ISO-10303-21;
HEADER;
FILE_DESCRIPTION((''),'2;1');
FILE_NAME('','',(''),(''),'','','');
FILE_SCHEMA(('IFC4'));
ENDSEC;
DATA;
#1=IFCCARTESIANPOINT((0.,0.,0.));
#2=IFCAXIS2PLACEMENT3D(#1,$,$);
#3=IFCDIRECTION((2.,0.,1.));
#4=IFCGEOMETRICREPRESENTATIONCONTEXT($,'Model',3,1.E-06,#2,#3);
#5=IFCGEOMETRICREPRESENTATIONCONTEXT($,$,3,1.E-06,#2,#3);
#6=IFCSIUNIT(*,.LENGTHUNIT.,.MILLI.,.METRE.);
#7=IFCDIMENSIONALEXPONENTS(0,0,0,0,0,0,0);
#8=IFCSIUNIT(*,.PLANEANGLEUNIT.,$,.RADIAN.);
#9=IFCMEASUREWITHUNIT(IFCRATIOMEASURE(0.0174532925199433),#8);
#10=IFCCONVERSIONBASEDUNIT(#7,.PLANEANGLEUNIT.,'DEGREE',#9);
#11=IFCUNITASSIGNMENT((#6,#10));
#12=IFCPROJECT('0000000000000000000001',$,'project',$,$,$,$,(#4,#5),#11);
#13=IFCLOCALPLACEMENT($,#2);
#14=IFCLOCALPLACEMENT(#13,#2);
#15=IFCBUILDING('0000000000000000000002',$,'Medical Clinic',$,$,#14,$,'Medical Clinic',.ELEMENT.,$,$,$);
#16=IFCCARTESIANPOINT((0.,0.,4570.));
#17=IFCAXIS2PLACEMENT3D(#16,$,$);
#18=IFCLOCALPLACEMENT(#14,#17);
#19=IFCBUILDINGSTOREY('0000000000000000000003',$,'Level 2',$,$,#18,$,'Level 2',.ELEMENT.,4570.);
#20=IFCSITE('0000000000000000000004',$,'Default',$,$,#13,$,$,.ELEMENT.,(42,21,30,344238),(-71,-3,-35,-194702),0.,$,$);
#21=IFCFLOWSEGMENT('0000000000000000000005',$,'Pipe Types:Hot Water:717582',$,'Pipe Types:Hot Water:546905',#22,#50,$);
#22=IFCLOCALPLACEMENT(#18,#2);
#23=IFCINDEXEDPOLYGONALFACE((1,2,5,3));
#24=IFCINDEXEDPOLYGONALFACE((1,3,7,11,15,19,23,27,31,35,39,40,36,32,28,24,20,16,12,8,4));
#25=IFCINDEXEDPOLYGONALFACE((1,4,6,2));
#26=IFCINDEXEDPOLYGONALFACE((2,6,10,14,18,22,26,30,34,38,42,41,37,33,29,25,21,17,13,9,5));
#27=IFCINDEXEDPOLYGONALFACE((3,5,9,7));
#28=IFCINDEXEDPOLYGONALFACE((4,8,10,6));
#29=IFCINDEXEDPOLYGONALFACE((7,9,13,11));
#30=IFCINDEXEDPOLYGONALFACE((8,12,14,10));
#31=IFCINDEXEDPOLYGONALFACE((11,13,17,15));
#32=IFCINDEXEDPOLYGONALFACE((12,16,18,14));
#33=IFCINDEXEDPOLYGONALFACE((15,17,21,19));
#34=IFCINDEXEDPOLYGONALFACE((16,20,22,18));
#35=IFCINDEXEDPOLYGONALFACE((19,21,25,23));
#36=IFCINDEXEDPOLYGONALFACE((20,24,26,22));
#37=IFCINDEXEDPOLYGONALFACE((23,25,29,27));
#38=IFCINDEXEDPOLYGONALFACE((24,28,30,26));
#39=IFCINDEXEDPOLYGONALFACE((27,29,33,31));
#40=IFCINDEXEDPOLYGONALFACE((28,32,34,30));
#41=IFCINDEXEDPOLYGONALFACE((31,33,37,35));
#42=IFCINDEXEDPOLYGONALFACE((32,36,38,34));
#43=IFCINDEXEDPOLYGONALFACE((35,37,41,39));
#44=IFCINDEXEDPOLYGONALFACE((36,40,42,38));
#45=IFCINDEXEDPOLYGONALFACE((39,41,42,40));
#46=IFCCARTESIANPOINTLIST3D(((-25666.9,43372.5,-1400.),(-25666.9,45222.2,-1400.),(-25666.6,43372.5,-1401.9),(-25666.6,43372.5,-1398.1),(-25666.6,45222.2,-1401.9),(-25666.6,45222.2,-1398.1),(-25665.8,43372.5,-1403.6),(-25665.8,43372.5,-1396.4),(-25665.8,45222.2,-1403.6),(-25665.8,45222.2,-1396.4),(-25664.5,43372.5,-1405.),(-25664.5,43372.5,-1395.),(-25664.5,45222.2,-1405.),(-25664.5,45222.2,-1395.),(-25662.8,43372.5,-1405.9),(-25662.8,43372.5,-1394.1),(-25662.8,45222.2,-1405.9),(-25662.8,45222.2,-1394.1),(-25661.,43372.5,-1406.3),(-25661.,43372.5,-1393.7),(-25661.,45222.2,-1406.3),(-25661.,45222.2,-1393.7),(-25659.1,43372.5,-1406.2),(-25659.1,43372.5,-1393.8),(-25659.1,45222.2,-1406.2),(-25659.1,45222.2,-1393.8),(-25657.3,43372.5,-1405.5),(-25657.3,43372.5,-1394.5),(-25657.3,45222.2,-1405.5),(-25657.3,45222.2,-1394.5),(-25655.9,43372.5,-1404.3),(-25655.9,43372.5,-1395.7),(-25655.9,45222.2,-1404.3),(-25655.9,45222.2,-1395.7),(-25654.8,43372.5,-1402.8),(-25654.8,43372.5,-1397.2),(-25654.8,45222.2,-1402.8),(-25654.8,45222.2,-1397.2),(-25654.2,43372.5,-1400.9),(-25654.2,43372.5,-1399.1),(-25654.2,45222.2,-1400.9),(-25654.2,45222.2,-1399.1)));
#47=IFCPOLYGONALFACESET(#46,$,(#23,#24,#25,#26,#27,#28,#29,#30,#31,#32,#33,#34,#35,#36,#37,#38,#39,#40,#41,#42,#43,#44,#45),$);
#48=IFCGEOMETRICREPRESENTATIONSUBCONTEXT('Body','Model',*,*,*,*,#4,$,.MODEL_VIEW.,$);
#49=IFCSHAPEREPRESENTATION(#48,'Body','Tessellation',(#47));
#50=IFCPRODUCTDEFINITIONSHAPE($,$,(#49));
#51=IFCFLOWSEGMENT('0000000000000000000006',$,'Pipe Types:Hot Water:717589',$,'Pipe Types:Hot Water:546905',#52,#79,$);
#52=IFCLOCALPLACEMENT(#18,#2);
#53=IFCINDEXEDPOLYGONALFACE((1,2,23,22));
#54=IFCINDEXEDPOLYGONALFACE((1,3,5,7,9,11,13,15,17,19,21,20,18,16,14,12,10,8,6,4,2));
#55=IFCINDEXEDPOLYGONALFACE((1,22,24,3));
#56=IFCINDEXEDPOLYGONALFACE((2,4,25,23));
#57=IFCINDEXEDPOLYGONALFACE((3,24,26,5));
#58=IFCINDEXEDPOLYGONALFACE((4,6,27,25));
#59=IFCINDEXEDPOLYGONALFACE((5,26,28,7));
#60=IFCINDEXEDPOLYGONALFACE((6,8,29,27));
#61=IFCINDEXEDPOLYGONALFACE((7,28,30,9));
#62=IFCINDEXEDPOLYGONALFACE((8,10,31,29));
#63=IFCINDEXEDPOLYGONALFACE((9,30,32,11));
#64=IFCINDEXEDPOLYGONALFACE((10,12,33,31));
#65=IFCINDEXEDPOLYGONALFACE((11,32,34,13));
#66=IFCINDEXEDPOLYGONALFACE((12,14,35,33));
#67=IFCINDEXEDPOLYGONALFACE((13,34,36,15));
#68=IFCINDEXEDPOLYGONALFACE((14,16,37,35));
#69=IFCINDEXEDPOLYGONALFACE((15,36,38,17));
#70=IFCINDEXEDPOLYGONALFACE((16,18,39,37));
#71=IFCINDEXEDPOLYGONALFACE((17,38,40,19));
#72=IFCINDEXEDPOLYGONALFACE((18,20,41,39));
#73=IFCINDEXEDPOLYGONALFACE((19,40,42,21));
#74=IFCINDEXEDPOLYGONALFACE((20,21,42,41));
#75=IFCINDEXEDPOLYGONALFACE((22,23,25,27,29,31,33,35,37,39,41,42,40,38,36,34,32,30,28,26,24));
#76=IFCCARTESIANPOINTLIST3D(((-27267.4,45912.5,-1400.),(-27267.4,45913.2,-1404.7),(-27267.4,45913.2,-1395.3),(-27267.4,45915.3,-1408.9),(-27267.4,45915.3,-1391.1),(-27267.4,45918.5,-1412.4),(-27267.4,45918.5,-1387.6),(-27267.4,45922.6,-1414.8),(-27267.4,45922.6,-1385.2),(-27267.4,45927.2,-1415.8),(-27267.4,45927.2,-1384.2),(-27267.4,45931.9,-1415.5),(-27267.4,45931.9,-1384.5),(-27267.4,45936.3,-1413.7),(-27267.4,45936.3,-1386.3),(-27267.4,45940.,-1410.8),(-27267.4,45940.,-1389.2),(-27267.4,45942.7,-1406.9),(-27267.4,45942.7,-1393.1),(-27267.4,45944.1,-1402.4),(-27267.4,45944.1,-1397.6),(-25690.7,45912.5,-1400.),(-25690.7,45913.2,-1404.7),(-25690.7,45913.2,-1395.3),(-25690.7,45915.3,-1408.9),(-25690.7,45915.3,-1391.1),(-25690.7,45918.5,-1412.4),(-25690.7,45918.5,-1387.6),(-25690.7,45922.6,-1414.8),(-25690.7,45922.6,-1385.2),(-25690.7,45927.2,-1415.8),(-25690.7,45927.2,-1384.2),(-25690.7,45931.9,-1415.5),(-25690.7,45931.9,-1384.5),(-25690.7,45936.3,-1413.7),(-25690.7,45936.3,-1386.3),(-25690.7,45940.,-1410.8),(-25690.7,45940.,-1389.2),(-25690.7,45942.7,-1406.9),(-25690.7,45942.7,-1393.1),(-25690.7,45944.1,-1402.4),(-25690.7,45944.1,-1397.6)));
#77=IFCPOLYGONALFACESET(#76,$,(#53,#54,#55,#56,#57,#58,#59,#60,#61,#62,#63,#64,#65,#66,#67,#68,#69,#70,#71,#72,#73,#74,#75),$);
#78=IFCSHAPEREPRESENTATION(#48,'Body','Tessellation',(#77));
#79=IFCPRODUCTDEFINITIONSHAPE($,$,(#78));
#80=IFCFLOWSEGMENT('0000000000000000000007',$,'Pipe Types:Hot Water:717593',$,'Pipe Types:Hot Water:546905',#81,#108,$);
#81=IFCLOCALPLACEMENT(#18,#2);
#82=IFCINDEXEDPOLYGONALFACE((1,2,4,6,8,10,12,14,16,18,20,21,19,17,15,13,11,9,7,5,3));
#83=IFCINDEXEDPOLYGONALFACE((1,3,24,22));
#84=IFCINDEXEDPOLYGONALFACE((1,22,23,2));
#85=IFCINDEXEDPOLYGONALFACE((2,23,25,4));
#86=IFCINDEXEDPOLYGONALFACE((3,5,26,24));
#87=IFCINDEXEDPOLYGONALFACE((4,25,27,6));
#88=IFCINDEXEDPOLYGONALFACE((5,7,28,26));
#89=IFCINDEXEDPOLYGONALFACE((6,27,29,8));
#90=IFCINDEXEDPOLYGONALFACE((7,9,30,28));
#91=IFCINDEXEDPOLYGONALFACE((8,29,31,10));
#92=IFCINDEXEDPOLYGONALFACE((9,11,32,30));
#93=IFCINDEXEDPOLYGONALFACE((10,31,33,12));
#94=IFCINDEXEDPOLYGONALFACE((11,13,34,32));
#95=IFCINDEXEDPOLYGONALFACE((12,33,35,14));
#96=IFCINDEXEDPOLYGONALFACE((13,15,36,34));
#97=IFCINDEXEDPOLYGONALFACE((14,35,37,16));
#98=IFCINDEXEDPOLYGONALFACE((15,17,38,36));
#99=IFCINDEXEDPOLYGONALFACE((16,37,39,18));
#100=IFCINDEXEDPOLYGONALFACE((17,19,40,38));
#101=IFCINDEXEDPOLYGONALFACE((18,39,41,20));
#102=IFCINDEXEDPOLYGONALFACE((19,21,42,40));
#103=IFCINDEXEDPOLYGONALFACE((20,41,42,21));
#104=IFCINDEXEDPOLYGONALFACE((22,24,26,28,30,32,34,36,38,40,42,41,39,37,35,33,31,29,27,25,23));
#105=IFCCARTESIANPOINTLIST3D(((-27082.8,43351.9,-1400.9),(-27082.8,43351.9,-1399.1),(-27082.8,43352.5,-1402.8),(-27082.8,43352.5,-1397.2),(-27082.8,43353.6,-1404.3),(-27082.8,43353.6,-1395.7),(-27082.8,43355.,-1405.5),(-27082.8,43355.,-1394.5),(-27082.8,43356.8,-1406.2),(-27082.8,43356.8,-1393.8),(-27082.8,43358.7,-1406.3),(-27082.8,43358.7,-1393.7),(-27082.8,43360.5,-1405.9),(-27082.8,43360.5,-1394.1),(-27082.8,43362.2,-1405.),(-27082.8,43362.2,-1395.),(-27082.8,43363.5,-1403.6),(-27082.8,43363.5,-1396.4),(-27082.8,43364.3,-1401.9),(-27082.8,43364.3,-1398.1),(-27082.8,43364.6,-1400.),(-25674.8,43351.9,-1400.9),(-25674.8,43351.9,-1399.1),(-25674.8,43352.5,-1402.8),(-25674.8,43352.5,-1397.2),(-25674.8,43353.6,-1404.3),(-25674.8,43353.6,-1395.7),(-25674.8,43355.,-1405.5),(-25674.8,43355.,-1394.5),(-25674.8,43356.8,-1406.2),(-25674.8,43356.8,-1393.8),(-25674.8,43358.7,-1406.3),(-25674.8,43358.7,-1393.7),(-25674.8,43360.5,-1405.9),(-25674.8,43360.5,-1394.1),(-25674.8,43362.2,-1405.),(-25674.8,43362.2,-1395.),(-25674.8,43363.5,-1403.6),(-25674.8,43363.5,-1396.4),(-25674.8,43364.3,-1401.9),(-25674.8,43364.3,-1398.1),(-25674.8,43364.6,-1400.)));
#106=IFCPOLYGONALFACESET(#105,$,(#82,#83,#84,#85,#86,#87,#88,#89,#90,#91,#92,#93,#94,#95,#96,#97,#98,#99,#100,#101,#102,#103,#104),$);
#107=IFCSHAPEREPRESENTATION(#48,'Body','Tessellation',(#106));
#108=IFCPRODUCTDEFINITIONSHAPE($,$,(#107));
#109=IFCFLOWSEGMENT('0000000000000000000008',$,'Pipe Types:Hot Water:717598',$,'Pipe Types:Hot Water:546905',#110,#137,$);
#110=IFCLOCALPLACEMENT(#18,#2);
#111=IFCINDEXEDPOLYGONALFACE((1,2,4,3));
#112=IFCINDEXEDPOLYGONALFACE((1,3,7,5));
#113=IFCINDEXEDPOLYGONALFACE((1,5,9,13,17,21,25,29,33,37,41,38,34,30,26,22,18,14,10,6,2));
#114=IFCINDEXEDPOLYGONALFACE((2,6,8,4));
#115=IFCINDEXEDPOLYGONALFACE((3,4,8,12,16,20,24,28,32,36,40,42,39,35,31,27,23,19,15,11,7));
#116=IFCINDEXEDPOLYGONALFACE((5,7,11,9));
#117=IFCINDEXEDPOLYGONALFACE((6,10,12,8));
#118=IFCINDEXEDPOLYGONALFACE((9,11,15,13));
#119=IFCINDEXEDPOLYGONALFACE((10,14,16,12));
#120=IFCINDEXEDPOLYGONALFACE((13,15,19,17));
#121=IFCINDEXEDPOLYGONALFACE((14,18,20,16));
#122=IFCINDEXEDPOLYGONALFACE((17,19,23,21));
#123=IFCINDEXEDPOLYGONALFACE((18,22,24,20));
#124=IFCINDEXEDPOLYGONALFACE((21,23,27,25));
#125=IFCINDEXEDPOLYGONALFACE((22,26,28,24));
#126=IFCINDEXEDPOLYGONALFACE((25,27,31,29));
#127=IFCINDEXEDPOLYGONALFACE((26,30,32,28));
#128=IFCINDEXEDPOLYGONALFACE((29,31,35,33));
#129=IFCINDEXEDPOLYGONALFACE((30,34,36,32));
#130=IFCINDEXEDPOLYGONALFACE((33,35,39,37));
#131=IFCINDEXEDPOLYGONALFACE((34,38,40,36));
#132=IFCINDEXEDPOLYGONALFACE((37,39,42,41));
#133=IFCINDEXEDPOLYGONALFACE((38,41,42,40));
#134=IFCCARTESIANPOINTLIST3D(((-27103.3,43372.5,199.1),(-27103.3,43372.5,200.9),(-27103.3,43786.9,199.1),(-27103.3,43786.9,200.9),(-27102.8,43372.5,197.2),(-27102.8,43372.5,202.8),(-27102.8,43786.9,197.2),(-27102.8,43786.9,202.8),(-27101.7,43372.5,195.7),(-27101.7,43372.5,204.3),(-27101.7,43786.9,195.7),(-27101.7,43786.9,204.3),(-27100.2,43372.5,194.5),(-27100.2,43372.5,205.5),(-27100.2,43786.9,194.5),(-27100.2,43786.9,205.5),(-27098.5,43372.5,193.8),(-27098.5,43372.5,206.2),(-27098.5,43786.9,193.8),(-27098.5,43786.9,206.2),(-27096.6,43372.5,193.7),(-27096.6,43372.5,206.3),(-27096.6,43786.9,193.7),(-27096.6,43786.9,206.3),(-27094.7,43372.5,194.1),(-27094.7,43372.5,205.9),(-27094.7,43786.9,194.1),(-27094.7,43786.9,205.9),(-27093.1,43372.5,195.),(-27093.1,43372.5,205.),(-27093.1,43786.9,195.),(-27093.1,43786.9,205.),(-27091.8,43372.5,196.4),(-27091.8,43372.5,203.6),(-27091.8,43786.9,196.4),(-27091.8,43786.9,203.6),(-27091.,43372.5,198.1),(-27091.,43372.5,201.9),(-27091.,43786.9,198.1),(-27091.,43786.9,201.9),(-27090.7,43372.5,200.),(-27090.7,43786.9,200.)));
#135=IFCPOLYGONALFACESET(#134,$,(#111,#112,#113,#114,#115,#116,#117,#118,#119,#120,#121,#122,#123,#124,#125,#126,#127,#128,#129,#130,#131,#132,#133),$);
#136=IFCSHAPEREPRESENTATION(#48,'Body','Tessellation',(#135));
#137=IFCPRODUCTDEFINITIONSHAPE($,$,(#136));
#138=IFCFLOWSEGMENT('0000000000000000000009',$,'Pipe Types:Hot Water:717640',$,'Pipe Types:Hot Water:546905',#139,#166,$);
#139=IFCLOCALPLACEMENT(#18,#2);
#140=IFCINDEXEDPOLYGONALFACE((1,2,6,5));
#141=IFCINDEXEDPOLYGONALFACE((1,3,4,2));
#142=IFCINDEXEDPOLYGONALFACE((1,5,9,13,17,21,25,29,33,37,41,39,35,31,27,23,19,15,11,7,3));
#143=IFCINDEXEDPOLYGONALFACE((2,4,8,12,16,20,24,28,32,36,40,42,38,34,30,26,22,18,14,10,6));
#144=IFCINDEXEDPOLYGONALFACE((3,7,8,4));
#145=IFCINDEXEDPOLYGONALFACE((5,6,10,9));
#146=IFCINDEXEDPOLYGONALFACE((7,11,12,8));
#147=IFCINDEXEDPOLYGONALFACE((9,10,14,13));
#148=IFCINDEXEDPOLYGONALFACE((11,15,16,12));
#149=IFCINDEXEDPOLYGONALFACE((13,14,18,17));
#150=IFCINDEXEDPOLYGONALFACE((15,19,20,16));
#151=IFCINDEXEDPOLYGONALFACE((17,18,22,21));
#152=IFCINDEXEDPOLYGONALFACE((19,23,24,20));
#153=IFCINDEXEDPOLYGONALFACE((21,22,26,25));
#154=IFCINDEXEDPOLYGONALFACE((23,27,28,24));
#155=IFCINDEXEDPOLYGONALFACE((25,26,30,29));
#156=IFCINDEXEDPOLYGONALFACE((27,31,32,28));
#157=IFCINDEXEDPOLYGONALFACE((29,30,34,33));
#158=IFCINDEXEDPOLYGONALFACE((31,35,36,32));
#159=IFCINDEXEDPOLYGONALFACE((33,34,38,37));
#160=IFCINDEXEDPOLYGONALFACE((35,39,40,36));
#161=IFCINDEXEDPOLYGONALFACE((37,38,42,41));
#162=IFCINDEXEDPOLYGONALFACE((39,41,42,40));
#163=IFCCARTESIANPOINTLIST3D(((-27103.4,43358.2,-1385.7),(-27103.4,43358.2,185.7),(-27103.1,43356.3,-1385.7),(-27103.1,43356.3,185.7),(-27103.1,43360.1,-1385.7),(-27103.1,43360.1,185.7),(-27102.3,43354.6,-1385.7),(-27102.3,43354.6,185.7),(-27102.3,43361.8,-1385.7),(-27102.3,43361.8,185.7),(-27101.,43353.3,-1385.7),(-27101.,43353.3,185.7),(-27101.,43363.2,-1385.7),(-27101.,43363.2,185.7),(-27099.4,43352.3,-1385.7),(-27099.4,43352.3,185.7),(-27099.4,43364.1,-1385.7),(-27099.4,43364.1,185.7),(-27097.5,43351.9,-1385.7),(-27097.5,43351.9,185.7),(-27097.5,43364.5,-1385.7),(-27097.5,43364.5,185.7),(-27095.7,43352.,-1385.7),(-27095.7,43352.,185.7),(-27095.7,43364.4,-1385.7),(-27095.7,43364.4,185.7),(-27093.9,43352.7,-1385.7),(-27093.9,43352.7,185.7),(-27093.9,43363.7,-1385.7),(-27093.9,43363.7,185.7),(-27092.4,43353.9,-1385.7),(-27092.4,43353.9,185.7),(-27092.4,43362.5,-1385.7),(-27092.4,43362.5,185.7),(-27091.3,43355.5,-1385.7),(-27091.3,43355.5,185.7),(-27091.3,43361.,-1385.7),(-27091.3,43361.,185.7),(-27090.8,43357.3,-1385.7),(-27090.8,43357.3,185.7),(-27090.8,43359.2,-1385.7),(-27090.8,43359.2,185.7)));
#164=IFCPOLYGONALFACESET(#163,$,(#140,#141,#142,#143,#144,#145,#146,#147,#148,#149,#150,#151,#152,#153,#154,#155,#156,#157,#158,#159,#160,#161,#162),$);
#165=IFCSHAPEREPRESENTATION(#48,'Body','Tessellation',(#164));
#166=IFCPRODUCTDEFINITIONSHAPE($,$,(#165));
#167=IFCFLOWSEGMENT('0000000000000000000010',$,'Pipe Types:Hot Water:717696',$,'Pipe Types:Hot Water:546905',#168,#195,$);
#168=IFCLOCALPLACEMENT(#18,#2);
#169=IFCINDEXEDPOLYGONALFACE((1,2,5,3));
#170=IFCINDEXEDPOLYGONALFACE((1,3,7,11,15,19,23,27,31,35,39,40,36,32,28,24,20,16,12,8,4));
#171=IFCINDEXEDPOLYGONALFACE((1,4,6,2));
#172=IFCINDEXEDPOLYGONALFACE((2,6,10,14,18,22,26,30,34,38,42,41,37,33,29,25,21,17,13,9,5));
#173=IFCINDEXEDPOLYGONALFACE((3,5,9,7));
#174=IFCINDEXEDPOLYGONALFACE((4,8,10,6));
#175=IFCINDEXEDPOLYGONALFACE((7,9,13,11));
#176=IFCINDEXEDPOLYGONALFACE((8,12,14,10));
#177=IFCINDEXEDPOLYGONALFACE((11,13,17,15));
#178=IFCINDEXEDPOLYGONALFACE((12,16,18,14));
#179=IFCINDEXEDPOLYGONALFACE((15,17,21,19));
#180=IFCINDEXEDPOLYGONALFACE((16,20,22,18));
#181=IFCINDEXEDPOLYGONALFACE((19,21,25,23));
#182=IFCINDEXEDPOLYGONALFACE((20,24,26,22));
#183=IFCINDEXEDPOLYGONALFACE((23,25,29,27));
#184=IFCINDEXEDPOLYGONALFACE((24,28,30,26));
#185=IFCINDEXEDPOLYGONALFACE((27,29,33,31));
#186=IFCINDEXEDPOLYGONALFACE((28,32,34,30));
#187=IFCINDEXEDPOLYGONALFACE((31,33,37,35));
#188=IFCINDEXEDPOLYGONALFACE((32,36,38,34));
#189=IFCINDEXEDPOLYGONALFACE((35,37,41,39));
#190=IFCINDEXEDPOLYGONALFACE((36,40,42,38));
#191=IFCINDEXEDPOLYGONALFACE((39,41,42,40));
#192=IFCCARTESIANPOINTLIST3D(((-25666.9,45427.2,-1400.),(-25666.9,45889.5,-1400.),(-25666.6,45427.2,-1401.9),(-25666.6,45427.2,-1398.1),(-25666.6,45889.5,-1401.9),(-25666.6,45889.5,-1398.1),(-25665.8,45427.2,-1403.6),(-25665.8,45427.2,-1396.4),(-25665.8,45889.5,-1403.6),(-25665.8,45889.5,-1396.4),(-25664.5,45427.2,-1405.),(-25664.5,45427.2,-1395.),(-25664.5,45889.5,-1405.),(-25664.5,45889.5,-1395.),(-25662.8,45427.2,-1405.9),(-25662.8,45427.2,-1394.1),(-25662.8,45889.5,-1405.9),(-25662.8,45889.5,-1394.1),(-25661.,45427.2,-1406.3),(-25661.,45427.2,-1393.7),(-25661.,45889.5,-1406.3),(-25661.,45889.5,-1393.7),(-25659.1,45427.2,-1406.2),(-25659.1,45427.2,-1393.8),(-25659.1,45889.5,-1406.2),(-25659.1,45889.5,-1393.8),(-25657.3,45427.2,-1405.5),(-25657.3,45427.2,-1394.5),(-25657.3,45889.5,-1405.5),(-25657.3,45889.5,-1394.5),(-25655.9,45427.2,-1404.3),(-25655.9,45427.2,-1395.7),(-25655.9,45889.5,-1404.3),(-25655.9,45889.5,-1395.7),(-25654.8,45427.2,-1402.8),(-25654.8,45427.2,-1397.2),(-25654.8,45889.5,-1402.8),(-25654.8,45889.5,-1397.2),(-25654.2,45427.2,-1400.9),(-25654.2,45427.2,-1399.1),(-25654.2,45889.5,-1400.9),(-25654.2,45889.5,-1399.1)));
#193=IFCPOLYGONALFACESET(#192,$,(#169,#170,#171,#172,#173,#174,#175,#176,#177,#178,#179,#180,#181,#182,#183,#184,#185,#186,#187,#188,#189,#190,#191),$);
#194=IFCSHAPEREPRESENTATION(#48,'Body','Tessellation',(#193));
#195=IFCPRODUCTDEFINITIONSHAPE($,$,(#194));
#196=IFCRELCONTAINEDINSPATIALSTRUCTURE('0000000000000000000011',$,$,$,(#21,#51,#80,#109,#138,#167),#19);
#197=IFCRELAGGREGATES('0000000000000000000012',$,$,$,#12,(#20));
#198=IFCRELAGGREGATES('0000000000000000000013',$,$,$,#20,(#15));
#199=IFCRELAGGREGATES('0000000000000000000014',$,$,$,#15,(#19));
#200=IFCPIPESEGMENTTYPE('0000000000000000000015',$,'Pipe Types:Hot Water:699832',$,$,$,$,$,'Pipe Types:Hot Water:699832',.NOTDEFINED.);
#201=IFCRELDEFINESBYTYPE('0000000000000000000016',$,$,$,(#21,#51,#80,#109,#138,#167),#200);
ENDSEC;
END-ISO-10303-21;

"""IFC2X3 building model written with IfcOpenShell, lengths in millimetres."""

from ifc_helpers import new_model, entity, si_unit, converted_unit, direction, frame, frame_2d, origin, origin_2d_with_axis, place, context, subcontext, project, spatial, circle, extrude, type_object, element, save


model = new_model("IFC2X3")

# Units and contexts
model_context = context("Model", 3, precision=1e-06, world=origin(), true_north=direction((2.0, 0.0, 1.0)))
context_of_model = context(None, 3, precision=1e-06, world=origin(), true_north=direction((2.0, 0.0, 1.0)))
body_context = subcontext(model_context, "Body", "Model", "MODEL_VIEW")
ifc_project = project(units=[si_unit("LENGTHUNIT", "METRE", prefix="MILLI"), converted_unit("PLANEANGLEUNIT", "DEGREE", entity("IfcRatioMeasure", 0.0174532925199433), si_unit("PLANEANGLEUNIT", "RADIAN"), dimensions=[0, 0, 0, 0, 0, 0, 0])], contexts=[model_context, context_of_model])

# Site, building, storey
site_placement = place(None, origin())
site = spatial("IfcSite", under=ifc_project, at=site_placement, Name="Default", CompositionType="ELEMENT", RefLatitude=(42, 21, 30, 344238), RefLongitude=(-71, -3, -35, -194702), RefElevation=0.0)
building_placement = place(site_placement, origin())
building = spatial("IfcBuilding", under=site, at=building_placement, Name="Medical Clinic", LongName="Medical Clinic", CompositionType="ELEMENT")
storey_placement = place(building_placement, frame((0.0, 0.0, 4570.0)))
storey = spatial("IfcBuildingStorey", under=building, at=storey_placement, Name="Level 2", LongName="Level 2", CompositionType="ELEMENT", Elevation=4570.0)

# Flow segments
pipe_segment_type = type_object("IfcPipeSegmentType", Name="Pipe Types:Hot Water:699832", ElementType="Pipe Types:Hot Water:699832", PredefinedType="NOTDEFINED")
flow_segment_1_placement = place(storey_placement, origin())
element("IfcFlowSegment", 1, at=flow_segment_1_placement, inside=storey, type_object=pipe_segment_type, Name="Pipe Types:Hot Water:717582", ObjectType="Pipe Types:Hot Water:546905", context=body_context, shape_type="SweptSolid", body=[
    extrude(circle(Radius=6.3, at=frame_2d((0.0, 0.0), x_axis=(1.0, 0.0))), frame((-25660.5, 43372.5, -1400.0), z_axis=(0.0, 1.0, 0.0), x_axis=(-1.0, 0.0, 0.0)), (0.0, 0.0, 1.0), 1849.7),
])
flow_segment_2_placement = place(storey_placement, origin())
element("IfcFlowSegment", 2, at=flow_segment_2_placement, inside=storey, type_object=pipe_segment_type, Name="Pipe Types:Hot Water:717589", ObjectType="Pipe Types:Hot Water:546905", context=body_context, shape_type="SweptSolid", body=[
    extrude(circle(Radius=15.9, at=origin_2d_with_axis()), frame((-27267.4, 45928.4, -1400.0), z_axis=(1.0, 0.0, 0.0), x_axis=(0.0, -1.0, 0.0)), (0.0, 0.0, 1.0), 1576.7),
])
flow_segment_3_placement = place(storey_placement, origin())
element("IfcFlowSegment", 3, at=flow_segment_3_placement, inside=storey, type_object=pipe_segment_type, Name="Pipe Types:Hot Water:717593", ObjectType="Pipe Types:Hot Water:546905", context=body_context, shape_type="SweptSolid", body=[
    extrude(circle(Radius=6.3, at=origin_2d_with_axis()), frame((-27082.8, 43358.2, -1400.0), z_axis=(1.0, 0.0, 0.0), x_axis=(0.0, 1.0, 0.0)), (0.0, 0.0, 1.0), 1408.0),
])
flow_segment_4_placement = place(storey_placement, origin())
element("IfcFlowSegment", 4, at=flow_segment_4_placement, inside=storey, type_object=pipe_segment_type, Name="Pipe Types:Hot Water:717598", ObjectType="Pipe Types:Hot Water:546905", context=body_context, shape_type="SweptSolid", body=[
    extrude(circle(Radius=6.3, at=origin_2d_with_axis()), frame((-27097.1, 43372.5, 200.0), z_axis=(0.0, 1.0, 0.0), x_axis=(1.0, 0.0, 0.0)), (0.0, 0.0, 1.0), 414.4),
])
flow_segment_5_placement = place(storey_placement, origin())
element("IfcFlowSegment", 5, at=flow_segment_5_placement, inside=storey, type_object=pipe_segment_type, Name="Pipe Types:Hot Water:717640", ObjectType="Pipe Types:Hot Water:546905", context=body_context, shape_type="SweptSolid", body=[
    extrude(circle(Radius=6.3, at=origin_2d_with_axis()), frame((-27097.1, 43358.2, -1385.7), z_axis=(0.0, 0.0, 1.0), x_axis=(-1.0, 0.0, 0.0)), (0.0, 0.0, 1.0), 1571.4),
])
flow_segment_6_placement = place(storey_placement, origin())
element("IfcFlowSegment", 6, at=flow_segment_6_placement, inside=storey, type_object=pipe_segment_type, Name="Pipe Types:Hot Water:717696", ObjectType="Pipe Types:Hot Water:546905", context=body_context, shape_type="SweptSolid", body=[
    extrude(circle(Radius=6.3, at=frame_2d((0.0, 0.0), x_axis=(1.0, 0.0))), frame((-25660.5, 45427.2, -1400.0), z_axis=(0.0, 1.0, 0.0), x_axis=(-1.0, 0.0, 0.0)), (0.0, 0.0, 1.0), 462.2),
])

save(model, "model.ifc")
